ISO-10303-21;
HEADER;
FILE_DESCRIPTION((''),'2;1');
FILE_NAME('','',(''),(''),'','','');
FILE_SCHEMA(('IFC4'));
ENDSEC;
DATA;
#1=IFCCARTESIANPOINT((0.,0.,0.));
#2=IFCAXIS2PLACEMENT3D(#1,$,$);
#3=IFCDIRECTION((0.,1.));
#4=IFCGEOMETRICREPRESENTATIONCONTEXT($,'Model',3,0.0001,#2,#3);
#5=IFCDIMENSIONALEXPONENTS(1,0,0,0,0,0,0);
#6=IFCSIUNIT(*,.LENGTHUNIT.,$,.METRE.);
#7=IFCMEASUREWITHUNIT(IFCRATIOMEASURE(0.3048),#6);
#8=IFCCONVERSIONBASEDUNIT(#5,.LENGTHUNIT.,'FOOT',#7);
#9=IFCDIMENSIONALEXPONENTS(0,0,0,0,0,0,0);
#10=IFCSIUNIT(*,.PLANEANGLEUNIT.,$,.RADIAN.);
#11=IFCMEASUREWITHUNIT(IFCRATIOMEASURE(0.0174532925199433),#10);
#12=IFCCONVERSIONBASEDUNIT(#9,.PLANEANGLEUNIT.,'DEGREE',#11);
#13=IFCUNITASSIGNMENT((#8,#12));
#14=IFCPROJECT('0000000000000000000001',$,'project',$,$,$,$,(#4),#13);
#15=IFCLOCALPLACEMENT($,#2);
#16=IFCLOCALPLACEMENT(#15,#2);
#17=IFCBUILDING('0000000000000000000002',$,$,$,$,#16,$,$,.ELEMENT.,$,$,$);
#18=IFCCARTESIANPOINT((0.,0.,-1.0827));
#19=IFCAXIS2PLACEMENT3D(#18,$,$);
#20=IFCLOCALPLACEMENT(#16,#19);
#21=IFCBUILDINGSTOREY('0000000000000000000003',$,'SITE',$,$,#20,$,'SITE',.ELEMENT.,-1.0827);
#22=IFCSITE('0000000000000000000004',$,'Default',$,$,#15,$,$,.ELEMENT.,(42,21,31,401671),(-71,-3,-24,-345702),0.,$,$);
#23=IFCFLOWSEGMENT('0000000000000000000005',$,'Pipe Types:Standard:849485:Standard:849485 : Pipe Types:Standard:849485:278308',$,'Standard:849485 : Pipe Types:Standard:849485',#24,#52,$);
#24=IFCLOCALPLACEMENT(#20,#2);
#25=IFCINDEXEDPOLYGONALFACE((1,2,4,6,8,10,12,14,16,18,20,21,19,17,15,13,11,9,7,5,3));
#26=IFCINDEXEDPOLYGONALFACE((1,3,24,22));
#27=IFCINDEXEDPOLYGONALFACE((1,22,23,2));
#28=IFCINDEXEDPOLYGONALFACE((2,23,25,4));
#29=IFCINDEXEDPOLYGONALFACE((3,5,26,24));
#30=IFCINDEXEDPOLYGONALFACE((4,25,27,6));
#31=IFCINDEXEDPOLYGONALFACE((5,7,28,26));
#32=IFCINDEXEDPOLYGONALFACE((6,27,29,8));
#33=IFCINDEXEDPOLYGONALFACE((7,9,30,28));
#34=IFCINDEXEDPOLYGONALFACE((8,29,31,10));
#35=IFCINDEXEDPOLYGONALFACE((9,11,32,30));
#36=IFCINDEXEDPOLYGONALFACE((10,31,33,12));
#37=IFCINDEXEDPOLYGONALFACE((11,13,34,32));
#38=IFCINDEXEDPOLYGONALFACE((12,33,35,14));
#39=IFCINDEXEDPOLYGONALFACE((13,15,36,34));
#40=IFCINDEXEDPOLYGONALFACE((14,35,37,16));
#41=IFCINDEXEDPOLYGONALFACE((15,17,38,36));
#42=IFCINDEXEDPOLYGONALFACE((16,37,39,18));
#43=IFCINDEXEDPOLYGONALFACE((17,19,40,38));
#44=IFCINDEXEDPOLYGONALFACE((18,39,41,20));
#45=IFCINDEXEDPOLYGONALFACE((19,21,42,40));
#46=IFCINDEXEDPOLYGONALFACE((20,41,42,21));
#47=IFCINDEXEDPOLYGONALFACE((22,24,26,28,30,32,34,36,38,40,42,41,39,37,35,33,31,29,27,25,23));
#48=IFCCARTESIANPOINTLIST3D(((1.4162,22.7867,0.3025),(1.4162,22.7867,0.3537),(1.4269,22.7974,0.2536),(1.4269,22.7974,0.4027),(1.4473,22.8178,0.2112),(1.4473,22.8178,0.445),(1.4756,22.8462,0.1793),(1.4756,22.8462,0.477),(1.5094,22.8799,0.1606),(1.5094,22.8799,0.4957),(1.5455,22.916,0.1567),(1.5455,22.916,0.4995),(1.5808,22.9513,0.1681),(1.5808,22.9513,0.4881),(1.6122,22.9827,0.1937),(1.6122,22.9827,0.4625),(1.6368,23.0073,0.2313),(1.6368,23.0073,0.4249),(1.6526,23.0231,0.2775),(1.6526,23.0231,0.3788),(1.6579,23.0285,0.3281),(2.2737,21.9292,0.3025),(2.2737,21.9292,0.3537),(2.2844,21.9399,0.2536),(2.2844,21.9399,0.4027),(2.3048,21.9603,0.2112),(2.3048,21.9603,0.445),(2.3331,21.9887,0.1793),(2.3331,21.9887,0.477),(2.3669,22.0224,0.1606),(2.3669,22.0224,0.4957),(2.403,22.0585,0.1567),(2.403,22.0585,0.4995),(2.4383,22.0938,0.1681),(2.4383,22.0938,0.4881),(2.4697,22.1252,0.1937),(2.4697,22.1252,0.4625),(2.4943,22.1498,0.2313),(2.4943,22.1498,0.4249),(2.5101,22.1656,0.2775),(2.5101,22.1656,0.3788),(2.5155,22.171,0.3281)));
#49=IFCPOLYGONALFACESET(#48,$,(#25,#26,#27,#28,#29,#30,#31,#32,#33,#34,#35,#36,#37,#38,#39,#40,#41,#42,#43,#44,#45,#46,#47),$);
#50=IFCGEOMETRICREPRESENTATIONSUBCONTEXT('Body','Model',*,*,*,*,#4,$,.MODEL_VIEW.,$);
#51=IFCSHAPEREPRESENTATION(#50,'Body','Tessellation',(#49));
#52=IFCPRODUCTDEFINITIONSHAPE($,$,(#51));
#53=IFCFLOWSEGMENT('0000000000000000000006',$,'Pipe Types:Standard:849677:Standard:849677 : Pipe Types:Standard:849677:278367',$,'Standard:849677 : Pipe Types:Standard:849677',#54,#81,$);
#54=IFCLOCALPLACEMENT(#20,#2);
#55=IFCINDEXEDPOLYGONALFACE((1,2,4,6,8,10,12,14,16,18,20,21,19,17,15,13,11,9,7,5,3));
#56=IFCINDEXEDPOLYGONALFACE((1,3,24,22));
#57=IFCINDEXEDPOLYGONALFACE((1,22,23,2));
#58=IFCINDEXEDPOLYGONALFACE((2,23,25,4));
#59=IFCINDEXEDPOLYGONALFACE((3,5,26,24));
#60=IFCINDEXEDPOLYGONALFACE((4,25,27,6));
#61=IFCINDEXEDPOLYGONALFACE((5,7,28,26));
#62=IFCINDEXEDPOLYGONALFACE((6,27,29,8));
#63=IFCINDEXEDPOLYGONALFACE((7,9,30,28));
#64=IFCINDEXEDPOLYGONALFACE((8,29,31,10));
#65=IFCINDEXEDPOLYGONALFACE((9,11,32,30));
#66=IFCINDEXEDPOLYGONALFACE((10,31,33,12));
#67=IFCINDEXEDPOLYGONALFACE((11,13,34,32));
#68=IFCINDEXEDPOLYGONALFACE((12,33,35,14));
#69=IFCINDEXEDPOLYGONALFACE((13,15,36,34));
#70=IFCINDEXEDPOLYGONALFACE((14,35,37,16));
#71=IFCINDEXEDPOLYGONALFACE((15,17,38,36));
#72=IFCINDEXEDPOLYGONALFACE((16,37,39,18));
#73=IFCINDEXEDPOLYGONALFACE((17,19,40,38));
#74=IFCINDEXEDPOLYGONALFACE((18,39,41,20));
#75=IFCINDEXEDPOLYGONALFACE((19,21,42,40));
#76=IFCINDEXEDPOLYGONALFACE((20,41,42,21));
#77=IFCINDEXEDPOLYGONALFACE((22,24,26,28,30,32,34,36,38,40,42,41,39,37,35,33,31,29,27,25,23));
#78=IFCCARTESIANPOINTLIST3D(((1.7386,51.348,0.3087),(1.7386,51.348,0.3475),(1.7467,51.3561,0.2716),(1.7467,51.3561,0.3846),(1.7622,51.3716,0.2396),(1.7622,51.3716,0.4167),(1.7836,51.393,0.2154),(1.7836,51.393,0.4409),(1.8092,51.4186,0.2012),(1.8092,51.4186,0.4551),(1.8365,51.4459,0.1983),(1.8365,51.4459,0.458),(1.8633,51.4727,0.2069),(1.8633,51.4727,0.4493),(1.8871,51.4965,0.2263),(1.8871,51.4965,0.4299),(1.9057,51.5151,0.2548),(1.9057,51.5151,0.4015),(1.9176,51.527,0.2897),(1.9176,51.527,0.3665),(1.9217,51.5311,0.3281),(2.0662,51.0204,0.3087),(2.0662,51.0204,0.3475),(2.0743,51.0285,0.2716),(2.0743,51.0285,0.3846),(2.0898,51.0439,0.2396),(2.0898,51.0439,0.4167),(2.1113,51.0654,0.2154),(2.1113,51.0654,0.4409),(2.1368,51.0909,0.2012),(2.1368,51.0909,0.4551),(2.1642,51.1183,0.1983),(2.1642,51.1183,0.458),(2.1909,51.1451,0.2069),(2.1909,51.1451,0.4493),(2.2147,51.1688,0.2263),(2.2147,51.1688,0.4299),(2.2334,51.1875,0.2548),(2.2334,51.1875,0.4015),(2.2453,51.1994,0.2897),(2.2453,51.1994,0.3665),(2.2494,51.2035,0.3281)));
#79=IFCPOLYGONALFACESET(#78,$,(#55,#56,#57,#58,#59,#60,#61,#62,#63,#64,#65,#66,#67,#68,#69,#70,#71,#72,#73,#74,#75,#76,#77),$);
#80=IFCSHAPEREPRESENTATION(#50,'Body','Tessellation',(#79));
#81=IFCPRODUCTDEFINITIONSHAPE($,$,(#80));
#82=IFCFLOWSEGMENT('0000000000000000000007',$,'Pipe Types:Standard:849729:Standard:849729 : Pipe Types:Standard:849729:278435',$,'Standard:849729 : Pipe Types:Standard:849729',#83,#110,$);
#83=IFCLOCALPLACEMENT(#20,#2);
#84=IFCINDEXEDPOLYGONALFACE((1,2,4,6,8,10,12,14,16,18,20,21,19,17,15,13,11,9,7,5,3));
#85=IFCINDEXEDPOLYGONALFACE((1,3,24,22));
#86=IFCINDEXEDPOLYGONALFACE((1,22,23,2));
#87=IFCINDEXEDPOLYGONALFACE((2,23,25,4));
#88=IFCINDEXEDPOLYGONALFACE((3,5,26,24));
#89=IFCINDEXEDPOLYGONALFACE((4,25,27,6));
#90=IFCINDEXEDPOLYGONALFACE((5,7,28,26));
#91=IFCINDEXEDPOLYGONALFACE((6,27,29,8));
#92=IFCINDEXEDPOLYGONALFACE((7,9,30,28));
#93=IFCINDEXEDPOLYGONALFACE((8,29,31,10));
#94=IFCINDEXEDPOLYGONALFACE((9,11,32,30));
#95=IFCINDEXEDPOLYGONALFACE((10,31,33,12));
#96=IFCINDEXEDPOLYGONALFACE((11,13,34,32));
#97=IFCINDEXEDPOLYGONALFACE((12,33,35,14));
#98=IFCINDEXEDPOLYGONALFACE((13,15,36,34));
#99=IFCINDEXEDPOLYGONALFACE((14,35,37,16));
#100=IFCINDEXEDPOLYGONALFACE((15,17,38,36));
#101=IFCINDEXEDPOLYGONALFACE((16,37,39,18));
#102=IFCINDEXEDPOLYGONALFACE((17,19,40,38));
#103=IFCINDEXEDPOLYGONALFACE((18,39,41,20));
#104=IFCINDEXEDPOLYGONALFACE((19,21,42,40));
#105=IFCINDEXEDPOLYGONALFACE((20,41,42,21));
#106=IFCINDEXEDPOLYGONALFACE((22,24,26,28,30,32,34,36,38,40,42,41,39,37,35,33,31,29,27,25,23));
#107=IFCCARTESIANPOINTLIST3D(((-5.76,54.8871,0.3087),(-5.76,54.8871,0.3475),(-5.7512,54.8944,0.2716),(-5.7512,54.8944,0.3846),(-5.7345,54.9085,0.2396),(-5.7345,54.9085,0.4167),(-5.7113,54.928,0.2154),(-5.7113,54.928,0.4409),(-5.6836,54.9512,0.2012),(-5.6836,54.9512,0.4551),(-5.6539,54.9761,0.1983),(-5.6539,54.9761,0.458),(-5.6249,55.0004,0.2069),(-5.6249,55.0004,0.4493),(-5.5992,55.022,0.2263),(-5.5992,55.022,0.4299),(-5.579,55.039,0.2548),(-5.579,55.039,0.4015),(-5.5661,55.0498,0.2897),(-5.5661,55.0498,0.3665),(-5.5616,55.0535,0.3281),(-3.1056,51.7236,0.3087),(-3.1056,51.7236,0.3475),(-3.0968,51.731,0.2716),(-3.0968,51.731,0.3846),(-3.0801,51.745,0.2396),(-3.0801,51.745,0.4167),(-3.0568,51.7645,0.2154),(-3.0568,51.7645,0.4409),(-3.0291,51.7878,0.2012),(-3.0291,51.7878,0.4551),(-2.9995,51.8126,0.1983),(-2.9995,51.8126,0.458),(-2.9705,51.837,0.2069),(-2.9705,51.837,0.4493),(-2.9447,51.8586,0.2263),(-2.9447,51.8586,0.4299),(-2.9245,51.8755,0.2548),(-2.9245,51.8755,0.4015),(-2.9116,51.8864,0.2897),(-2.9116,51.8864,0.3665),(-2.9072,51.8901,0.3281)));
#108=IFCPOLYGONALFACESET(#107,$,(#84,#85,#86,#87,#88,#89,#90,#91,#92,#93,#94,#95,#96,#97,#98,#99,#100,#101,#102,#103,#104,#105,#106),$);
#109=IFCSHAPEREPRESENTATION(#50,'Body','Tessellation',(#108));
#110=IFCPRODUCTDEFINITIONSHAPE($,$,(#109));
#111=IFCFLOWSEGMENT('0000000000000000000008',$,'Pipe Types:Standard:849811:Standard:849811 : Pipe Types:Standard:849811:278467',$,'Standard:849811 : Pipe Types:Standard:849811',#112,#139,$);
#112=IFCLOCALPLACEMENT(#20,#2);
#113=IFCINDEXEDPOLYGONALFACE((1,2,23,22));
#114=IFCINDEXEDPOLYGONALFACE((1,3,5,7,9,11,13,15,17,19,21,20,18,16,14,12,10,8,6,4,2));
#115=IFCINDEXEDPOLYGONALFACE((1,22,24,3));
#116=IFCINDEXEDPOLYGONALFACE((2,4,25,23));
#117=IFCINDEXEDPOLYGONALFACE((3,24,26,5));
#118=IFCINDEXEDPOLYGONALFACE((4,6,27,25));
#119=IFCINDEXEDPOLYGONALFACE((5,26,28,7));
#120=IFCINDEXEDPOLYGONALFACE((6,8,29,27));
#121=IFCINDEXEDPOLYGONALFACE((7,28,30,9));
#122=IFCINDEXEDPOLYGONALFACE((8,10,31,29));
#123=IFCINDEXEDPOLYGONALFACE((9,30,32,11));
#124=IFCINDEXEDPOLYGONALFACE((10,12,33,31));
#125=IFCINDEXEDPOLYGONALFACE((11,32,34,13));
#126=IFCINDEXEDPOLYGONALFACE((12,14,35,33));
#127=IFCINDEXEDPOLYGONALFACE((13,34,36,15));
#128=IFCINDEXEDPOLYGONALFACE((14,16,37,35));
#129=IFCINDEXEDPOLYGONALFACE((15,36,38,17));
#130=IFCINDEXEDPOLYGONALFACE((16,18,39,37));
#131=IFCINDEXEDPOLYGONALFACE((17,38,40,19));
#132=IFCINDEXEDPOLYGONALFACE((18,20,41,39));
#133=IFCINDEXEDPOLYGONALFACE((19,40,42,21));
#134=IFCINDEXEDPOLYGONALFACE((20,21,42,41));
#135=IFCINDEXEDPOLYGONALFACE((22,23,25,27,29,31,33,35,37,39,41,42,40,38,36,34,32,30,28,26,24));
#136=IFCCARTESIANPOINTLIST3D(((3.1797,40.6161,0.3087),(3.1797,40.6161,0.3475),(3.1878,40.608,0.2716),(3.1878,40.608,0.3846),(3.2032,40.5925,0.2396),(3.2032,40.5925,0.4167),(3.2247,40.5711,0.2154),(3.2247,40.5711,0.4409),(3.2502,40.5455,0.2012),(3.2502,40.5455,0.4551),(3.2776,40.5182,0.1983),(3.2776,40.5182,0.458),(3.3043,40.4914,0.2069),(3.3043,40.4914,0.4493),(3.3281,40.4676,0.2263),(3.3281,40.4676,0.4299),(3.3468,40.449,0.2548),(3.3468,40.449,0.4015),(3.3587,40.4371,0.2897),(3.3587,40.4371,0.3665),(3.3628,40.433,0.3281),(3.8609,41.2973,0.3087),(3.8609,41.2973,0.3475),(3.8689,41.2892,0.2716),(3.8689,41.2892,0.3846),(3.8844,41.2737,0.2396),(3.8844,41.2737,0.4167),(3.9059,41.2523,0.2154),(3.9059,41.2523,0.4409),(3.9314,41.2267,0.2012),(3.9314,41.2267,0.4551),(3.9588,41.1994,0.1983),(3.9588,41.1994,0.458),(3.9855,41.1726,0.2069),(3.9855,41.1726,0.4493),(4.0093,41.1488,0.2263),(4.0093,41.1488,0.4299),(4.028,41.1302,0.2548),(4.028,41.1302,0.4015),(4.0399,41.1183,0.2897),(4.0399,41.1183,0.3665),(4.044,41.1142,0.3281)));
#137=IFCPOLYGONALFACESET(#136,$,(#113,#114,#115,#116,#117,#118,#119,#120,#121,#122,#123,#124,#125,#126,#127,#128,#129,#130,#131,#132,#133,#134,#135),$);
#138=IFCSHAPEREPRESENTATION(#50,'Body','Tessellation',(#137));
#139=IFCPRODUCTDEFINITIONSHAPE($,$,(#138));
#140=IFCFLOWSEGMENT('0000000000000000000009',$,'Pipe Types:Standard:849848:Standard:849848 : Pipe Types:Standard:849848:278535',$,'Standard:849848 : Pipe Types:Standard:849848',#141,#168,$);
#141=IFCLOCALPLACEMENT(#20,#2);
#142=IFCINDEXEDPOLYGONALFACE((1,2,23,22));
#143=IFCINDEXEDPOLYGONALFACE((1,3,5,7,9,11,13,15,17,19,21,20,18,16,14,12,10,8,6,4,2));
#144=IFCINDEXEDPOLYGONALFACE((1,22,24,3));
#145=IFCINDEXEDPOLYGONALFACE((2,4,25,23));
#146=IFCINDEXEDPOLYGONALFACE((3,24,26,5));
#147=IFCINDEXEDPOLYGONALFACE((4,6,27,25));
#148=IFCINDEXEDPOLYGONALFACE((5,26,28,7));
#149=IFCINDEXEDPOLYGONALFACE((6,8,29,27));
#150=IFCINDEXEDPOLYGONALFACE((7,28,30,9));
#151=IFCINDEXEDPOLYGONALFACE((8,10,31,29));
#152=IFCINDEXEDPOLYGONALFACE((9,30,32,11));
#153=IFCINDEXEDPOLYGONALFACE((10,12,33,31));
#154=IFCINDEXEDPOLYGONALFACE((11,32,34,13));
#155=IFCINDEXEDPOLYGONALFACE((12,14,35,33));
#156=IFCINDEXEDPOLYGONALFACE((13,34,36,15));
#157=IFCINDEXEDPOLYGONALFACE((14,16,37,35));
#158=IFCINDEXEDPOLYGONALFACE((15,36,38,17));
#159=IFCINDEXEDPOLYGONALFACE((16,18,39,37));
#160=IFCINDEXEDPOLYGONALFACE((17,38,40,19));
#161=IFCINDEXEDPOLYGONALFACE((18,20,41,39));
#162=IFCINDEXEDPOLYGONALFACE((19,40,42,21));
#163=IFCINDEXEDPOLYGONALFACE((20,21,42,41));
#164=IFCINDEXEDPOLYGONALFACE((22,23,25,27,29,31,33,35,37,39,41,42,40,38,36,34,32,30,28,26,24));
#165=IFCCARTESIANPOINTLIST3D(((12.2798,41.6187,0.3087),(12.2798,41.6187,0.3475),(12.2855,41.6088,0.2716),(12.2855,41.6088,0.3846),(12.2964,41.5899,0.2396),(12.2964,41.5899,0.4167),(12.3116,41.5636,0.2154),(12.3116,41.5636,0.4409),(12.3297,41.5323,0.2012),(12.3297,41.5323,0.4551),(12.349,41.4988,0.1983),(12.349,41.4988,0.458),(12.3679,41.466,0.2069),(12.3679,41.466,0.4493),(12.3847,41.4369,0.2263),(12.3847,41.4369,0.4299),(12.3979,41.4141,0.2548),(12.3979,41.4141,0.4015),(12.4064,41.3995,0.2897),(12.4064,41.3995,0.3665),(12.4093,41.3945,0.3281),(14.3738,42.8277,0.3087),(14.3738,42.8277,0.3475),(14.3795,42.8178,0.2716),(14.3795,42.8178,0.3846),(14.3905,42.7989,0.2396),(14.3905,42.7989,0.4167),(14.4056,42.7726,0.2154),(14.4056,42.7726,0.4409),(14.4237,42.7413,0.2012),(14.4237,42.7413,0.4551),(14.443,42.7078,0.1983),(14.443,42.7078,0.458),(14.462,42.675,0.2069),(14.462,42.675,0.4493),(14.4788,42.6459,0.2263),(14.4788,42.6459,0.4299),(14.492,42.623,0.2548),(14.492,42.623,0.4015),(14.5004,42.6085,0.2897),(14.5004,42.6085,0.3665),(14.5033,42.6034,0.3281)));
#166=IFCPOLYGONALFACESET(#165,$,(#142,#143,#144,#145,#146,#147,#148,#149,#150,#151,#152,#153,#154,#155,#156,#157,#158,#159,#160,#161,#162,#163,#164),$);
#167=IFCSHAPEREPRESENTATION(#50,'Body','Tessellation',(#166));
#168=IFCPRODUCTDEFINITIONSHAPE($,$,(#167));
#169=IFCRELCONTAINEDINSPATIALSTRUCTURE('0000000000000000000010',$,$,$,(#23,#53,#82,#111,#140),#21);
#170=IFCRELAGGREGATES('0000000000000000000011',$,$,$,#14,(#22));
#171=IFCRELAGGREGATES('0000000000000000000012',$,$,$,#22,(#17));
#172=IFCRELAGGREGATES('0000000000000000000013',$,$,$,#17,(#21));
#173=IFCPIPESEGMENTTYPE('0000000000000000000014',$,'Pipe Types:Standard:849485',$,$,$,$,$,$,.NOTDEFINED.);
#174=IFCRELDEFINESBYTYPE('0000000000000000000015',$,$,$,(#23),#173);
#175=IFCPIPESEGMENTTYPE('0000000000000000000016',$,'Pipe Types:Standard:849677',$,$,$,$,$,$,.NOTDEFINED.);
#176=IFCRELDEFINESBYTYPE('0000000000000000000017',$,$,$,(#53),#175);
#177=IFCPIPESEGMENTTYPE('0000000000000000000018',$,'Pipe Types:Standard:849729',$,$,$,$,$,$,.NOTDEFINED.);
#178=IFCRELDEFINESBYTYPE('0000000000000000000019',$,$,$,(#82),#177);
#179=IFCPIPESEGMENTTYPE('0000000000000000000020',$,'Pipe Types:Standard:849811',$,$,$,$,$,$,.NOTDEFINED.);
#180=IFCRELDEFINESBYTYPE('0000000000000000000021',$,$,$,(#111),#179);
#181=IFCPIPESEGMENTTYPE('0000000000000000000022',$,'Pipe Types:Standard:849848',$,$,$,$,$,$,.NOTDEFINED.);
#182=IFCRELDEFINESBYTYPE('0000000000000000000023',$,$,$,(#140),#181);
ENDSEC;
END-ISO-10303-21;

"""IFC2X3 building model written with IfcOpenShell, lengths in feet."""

from ifc_helpers import new_model, entity, si_unit, converted_unit, direction, frame, frame_2d, origin, place, context, subcontext, project, spatial, circle, extrude, source, transform, mapped, type_object, type_shapes, element, save


model = new_model("IFC2X3")

# Units and contexts
model_context = context("Model", 3, precision=0.0001, world=origin(), true_north=direction((0.0, 1.0)))
body_context = subcontext(model_context, "Body", "Model", "MODEL_VIEW")
ifc_project = project(units=[converted_unit("LENGTHUNIT", "FOOT", entity("IfcRatioMeasure", 0.3048), si_unit("LENGTHUNIT", "METRE"), dimensions=[1, 0, 0, 0, 0, 0, 0]), converted_unit("PLANEANGLEUNIT", "DEGREE", entity("IfcRatioMeasure", 0.0174532925199433), si_unit("PLANEANGLEUNIT", "RADIAN"), dimensions=[0, 0, 0, 0, 0, 0, 0])], contexts=[model_context])

# Site, building, storey
site_placement = place(None, origin())
site = spatial("IfcSite", under=ifc_project, at=site_placement, Name="Default", CompositionType="ELEMENT", RefLatitude=(42, 21, 31, 401671), RefLongitude=(-71, -3, -24, -345702), RefElevation=0.0)
building_placement = place(site_placement, origin())
building = spatial("IfcBuilding", under=site, at=building_placement, CompositionType="ELEMENT")
storey_placement = place(building_placement, frame((0.0, 0.0, -1.0827)))
storey = spatial("IfcBuildingStorey", under=building, at=storey_placement, Name="SITE", LongName="SITE", CompositionType="ELEMENT", Elevation=-1.0827)

# Flow segments
pipe_segment_type_1 = type_object("IfcPipeSegmentType", Name="Pipe Types:Standard:849485", PredefinedType="NOTDEFINED")
shared_shape_1 = source(origin(), body_context, "Body", "SweptSolid", [
    extrude(circle(Radius=0.1719, at=frame_2d((0.0, 0.0), x_axis=(1.0, 0.0))), frame((2.3939, 22.0494, -0.7546), z_axis=(-0.707107, 0.707107, 0.0), x_axis=(0.707107, 0.707107, 0.0)), (0.0, 0.0, 1.0), 1.2127),
])
type_shapes(pipe_segment_type_1, [shared_shape_1])
flow_segment_1_placement = place(storey_placement, frame((0.0, 0.0, 1.0827)))
element("IfcFlowSegment", 1, at=flow_segment_1_placement, inside=storey, type_object=pipe_segment_type_1, Name="Pipe Types:Standard:849485:Standard:849485 : Pipe Types:Standard:849485:278308", ObjectType="Standard:849485 : Pipe Types:Standard:849485", context=body_context, shape_type="MappedRepresentation", body=[
    mapped(shared_shape_1, transform((0.0, 0.0, 0.0), scale=1.0)),
])
pipe_segment_type_2 = type_object("IfcPipeSegmentType", Name="Pipe Types:Standard:849677", PredefinedType="NOTDEFINED")
shared_shape_2 = source(origin(), body_context, "Body", "SweptSolid", [
    extrude(circle(Radius=0.1302, at=frame_2d((0.0, 0.0), x_axis=(1.0, 0.0))), frame((1.8297, 51.4391, -0.7546), z_axis=(0.707107, -0.707107, 0.0), x_axis=(0.707107, 0.707107, 0.0)), (0.0, 0.0, 1.0), 0.4633),
])
type_shapes(pipe_segment_type_2, [shared_shape_2])
flow_segment_2_placement = place(storey_placement, frame((0.0, 0.0, 1.0827)))
element("IfcFlowSegment", 2, at=flow_segment_2_placement, inside=storey, type_object=pipe_segment_type_2, Name="Pipe Types:Standard:849677:Standard:849677 : Pipe Types:Standard:849677:278367", ObjectType="Standard:849677 : Pipe Types:Standard:849677", context=body_context, shape_type="MappedRepresentation", body=[
    mapped(shared_shape_2, transform((0.0, 0.0, 0.0), scale=1.0)),
])
pipe_segment_type_3 = type_object("IfcPipeSegmentType", Name="Pipe Types:Standard:849729", PredefinedType="NOTDEFINED")
shared_shape_3 = source(origin(), body_context, "Body", "SweptSolid", [
    extrude(circle(Radius=0.1302, at=frame_2d((0.0, 0.0), x_axis=(1.0, 0.0))), frame((-5.6614, 54.9698, -0.7546), z_axis=(0.642788, -0.766044, 0.0), x_axis=(0.766044, 0.642788, 0.0)), (0.0, 0.0, 1.0), 4.1296),
])
type_shapes(pipe_segment_type_3, [shared_shape_3])
flow_segment_3_placement = place(storey_placement, frame((0.0, 0.0, 1.0827)))
element("IfcFlowSegment", 3, at=flow_segment_3_placement, inside=storey, type_object=pipe_segment_type_3, Name="Pipe Types:Standard:849729:Standard:849729 : Pipe Types:Standard:849729:278435", ObjectType="Standard:849729 : Pipe Types:Standard:849729", context=body_context, shape_type="MappedRepresentation", body=[
    mapped(shared_shape_3, transform((0.0, 0.0, 0.0), scale=1.0)),
])
pipe_segment_type_4 = type_object("IfcPipeSegmentType", Name="Pipe Types:Standard:849811", PredefinedType="NOTDEFINED")
shared_shape_4 = source(origin(), body_context, "Body", "SweptSolid", [
    extrude(circle(Radius=0.1302, at=frame_2d((0.0, 0.0), x_axis=(1.0, 0.0))), frame((3.2707, 40.525, -0.7546), z_axis=(0.707107, 0.707107, 0.0), x_axis=(0.707107, -0.707107, 0.0)), (0.0, 0.0, 1.0), 0.9633),
])
type_shapes(pipe_segment_type_4, [shared_shape_4])
flow_segment_4_placement = place(storey_placement, frame((0.0, 0.0, 1.0827)))
element("IfcFlowSegment", 4, at=flow_segment_4_placement, inside=storey, type_object=pipe_segment_type_4, Name="Pipe Types:Standard:849811:Standard:849811 : Pipe Types:Standard:849811:278467", ObjectType="Standard:849811 : Pipe Types:Standard:849811", context=body_context, shape_type="MappedRepresentation", body=[
    mapped(shared_shape_4, transform((0.0, 0.0, 0.0), scale=1.0)),
])
pipe_segment_type_5 = type_object("IfcPipeSegmentType", Name="Pipe Types:Standard:849848", PredefinedType="NOTDEFINED")
shared_shape_5 = source(origin(), body_context, "Body", "SweptSolid", [
    extrude(circle(Radius=0.1302, at=frame_2d((0.0, 0.0), x_axis=(1.0, 0.0))), frame((12.3442, 41.5072, -0.7546), z_axis=(0.866025, 0.5, 0.0), x_axis=(0.5, -0.866025, 0.0)), (0.0, 0.0, 1.0), 2.418),
])
type_shapes(pipe_segment_type_5, [shared_shape_5])
flow_segment_5_placement = place(storey_placement, frame((0.0, 0.0, 1.0827)))
element("IfcFlowSegment", 5, at=flow_segment_5_placement, inside=storey, type_object=pipe_segment_type_5, Name="Pipe Types:Standard:849848:Standard:849848 : Pipe Types:Standard:849848:278535", ObjectType="Standard:849848 : Pipe Types:Standard:849848", context=body_context, shape_type="MappedRepresentation", body=[
    mapped(shared_shape_5, transform((0.0, 0.0, 0.0), scale=1.0)),
])

save(model, "model.ifc")
